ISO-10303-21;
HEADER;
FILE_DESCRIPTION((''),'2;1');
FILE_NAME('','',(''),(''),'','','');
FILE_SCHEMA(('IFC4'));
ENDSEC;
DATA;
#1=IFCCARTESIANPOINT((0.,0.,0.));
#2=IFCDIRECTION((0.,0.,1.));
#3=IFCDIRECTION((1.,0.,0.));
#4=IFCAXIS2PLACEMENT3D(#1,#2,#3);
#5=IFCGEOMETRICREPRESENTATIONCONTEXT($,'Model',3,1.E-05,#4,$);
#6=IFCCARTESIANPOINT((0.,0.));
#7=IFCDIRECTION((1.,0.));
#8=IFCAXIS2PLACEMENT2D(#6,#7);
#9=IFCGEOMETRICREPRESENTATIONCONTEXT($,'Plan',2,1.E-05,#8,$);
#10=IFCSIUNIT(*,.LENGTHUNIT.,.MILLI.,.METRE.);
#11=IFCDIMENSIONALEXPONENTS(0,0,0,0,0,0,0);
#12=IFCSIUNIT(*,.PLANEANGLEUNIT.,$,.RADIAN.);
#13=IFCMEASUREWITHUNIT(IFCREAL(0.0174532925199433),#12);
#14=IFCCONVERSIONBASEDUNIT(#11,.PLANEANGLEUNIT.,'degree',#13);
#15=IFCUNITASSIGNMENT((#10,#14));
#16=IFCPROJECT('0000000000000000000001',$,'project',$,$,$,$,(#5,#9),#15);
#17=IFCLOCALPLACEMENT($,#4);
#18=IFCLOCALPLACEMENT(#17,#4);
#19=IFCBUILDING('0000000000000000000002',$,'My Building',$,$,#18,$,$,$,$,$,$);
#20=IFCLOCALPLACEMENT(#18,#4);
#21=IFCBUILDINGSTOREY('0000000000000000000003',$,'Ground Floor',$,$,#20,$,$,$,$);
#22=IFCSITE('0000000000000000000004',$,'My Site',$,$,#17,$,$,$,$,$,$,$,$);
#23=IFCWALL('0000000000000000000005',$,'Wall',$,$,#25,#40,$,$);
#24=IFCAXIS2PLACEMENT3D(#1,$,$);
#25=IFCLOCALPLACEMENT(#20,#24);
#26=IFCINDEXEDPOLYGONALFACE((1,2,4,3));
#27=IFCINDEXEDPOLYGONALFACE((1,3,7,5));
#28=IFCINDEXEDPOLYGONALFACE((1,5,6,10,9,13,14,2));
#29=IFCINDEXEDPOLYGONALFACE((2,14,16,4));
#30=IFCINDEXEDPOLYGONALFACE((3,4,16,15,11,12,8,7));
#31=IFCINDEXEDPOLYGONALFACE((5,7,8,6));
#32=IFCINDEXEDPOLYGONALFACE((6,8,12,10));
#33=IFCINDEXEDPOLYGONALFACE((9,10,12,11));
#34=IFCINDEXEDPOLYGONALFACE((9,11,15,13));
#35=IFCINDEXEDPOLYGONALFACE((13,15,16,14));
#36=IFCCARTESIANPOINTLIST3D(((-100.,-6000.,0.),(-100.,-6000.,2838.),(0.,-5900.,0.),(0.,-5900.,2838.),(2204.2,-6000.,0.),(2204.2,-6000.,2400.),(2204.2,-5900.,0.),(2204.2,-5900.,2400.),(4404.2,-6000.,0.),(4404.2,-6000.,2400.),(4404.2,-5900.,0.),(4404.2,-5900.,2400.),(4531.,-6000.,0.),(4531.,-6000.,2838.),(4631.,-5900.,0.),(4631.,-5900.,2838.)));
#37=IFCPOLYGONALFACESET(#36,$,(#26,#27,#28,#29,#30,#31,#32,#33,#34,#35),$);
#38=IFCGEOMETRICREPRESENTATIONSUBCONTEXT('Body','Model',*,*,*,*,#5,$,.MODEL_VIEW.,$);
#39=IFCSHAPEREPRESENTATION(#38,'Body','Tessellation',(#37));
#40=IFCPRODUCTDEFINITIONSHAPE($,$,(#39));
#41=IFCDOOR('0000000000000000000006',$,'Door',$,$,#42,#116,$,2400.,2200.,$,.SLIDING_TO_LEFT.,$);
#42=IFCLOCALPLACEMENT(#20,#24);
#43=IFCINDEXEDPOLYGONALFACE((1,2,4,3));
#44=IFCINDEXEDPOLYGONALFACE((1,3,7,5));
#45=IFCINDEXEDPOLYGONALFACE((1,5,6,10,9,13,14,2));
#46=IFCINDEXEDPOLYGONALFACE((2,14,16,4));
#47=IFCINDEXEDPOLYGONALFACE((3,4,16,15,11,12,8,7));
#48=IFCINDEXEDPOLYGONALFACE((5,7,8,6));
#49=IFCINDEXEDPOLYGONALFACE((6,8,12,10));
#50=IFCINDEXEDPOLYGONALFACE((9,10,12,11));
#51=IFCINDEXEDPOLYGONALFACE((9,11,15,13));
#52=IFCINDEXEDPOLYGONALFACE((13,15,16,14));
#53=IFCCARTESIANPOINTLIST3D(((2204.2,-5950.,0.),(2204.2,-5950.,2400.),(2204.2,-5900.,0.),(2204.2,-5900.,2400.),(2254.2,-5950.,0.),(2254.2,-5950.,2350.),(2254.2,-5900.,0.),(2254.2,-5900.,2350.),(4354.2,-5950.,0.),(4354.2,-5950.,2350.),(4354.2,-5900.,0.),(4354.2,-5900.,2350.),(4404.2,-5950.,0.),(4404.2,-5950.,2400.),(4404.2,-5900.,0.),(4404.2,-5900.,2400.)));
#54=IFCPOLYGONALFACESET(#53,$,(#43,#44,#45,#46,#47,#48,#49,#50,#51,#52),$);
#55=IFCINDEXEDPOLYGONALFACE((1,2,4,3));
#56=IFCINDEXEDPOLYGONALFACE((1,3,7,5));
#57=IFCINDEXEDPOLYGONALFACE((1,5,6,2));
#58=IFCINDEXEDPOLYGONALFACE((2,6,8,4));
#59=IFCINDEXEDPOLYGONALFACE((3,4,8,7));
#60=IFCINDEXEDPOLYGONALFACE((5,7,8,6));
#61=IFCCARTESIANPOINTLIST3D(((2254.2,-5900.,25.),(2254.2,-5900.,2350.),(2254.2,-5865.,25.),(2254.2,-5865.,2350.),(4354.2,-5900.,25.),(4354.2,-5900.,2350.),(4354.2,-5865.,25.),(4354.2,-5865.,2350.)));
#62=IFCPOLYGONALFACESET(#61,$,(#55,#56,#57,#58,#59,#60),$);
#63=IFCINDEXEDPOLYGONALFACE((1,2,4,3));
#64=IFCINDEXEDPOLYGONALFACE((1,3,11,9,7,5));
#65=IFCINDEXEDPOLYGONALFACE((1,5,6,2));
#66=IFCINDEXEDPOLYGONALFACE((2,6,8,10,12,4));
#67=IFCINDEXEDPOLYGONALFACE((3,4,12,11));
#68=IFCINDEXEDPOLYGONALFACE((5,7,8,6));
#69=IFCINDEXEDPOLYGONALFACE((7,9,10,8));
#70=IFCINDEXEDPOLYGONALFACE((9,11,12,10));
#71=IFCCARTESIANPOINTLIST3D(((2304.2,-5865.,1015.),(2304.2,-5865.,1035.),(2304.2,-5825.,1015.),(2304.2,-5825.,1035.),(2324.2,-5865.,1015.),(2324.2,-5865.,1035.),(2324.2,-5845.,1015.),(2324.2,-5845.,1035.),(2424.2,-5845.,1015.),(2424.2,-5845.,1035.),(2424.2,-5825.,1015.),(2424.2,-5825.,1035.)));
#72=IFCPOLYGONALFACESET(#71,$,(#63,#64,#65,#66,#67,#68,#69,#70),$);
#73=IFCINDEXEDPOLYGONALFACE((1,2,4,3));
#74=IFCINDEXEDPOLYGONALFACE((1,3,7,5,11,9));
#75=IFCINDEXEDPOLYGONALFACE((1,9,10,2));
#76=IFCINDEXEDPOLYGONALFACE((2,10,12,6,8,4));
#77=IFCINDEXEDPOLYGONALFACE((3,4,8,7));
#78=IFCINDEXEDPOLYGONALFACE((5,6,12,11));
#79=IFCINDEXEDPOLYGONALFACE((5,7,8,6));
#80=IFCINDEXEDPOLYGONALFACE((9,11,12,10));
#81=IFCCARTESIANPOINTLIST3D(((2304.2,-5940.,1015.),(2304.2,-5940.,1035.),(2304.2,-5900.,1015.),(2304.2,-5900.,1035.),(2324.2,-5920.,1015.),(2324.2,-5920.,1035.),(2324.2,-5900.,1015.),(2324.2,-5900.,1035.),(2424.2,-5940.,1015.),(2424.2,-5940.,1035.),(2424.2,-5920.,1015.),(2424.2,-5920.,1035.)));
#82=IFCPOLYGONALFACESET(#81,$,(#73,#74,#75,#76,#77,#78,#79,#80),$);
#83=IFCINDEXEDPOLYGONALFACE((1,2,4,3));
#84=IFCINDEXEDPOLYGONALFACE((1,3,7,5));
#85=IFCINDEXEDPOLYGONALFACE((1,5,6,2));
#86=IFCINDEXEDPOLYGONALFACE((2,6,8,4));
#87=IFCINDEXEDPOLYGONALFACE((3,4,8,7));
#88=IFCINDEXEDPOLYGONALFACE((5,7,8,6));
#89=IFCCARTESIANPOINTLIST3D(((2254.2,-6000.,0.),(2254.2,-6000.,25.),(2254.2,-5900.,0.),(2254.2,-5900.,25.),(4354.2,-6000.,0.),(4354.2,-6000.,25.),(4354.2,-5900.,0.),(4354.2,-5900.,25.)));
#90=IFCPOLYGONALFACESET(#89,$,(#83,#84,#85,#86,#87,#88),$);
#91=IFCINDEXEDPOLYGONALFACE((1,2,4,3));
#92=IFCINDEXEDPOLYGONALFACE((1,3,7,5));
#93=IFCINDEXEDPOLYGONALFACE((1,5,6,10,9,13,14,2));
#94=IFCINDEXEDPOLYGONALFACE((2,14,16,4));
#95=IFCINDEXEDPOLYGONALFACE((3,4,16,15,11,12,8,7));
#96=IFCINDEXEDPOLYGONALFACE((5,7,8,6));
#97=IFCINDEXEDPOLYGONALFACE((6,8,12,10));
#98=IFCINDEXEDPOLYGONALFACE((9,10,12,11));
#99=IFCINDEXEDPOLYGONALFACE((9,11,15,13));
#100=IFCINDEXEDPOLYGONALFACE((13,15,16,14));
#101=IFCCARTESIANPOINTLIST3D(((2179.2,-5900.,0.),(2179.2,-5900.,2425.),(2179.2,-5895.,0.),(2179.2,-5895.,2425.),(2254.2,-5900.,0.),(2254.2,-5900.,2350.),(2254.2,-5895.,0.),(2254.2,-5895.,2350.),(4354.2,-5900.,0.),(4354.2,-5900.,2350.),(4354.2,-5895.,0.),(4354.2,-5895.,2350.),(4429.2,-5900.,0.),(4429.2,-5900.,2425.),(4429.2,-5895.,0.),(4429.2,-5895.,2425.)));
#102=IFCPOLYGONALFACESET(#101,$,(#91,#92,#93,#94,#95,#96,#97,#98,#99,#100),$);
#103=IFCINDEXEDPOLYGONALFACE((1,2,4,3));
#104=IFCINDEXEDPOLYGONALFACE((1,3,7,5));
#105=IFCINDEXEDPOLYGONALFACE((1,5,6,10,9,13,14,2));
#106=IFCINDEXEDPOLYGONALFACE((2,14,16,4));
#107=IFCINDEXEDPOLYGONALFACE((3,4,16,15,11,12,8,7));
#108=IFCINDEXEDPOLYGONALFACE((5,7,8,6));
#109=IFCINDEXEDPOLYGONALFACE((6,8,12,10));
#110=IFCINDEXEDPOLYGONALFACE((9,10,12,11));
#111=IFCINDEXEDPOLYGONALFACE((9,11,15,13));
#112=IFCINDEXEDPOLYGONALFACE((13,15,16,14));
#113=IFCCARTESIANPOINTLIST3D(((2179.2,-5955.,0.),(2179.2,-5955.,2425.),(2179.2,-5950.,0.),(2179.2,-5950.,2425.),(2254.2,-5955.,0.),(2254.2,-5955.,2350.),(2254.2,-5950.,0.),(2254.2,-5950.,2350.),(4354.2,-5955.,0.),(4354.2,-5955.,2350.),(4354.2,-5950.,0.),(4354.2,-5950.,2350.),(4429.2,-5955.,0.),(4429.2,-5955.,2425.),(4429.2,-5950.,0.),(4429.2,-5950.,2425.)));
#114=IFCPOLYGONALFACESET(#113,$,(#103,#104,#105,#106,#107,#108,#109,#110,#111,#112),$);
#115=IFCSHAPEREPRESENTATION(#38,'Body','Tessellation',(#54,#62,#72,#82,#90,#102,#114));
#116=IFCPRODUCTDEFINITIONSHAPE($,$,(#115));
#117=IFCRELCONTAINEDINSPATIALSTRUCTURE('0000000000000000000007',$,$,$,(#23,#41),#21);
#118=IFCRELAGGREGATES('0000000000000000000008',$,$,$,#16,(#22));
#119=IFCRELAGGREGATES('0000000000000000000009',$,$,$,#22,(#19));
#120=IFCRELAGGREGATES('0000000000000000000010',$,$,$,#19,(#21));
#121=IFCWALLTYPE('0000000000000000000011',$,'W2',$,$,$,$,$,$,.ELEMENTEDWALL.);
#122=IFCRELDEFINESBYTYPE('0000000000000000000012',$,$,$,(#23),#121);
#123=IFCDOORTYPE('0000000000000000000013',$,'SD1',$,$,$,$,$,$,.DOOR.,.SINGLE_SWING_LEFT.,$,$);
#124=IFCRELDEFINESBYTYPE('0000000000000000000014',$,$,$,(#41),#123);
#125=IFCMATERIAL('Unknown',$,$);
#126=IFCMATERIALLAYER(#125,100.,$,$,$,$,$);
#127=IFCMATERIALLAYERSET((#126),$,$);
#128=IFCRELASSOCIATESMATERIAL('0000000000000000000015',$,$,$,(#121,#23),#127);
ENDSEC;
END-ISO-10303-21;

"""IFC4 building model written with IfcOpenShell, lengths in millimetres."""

from ifc_helpers import new_model, entity, si_unit, converted_unit, frame, origin_with_axes, origin_2d_with_axis, place, context, subcontext, project, spatial, line, indexed_curve, outline, extrude, clip, halfspace, shape, source, transform, mapped, material, layer, layer_set, layer_usage, type_object, type_shapes, element, fill, save


model = new_model("IFC4")

# Units and contexts
model_context = context("Model", 3, precision=1e-05, world=origin_with_axes())
plan_context = context("Plan", 2, precision=1e-05, world=origin_2d_with_axis())
body_context_1 = subcontext(model_context, "Body", "Model", "MODEL_VIEW")
body_context_2 = subcontext(plan_context, "Body", "Plan", "PLAN_VIEW")
ifc_project = project(units=[si_unit("LENGTHUNIT", "METRE", prefix="MILLI"), converted_unit("PLANEANGLEUNIT", "degree", entity("IfcReal", 0.0174532925199433), si_unit("PLANEANGLEUNIT", "RADIAN"), dimensions=[0, 0, 0, 0, 0, 0, 0])], contexts=[model_context, plan_context])

# Site, building, storey
site_placement = place(None, origin_with_axes())
site = spatial("IfcSite", under=ifc_project, at=site_placement, Name="My Site")
building_placement = place(site_placement, origin_with_axes())
building = spatial("IfcBuilding", under=site, at=building_placement, Name="My Building")
storey_placement = place(building_placement, origin_with_axes())
storey = spatial("IfcBuildingStorey", under=building, at=storey_placement, Name="Ground Floor")

# Shared definitions
ifc_material = material(Name="Unknown")

# Shared definitions
ifc_layer_1 = layer(ifc_material, 100.0)
ifc_layer_set_1 = layer_set([ifc_layer_1])
wall_type = type_object("IfcWallType", Name="W2", PredefinedType="ELEMENTEDWALL", material=ifc_layer_set_1)

# Wall, opening, door
ifc_layer_usage_1 = layer_usage(ifc_layer_set_1, "AXIS2", "POSITIVE", 0.0)
wall_1_placement = place(storey_placement, frame((4631.0, -5900.0, 0.0), z_axis=(0.0, 0.0, 1.0), x_axis=(-1.0, 0.0, 0.0)))
wall_1 = element("IfcWall", 1, at=wall_1_placement, inside=storey, type_object=wall_type, material=ifc_layer_usage_1, Name="Wall", context=body_context_1, shape_type="Clipping", body=[
    clip(clip(extrude(outline(indexed_curve([(0.0, 0.0), (0.0, 100.0), (4731.0, 100.0), (4731.0, 0.0), (0.0, 0.0)], self_intersect=False)), origin_with_axes(), (0.0, 0.0, 1.0), 2838.0), halfspace(frame((4631.0, 0.0, 0.0), z_axis=(0.707107, -0.707107, 0.0), x_axis=(-0.707107, -0.707107, 0.0)), False)), halfspace(frame((0.0, 0.0, 0.0), z_axis=(-0.707107, 0.707106, 0.0), x_axis=(0.707106, 0.707107, 0.0)), False)),
])
shared_shape_1 = source(origin_with_axes(), body_context_1, "Body", "SolidModel", [
    extrude(outline(indexed_curve([(0.0, 0.0), (2200.0, 0.0), (2200.0, 2400.0), (0.0, 2400.0)], segments=[line(1, 2, 3, 4, 1)])), frame((0.0, -600.0, 0.0), z_axis=(0.0, -1.0, 0.0), x_axis=(1.0, 0.0, 0.0)), (0.0, 0.0, -1.0), 1200.0),
])
opening_1_placement = place(wall_1_placement, frame((226.8, 0.0, 0.0), z_axis=(0.0, 0.0, 1.0), x_axis=(1.0, 0.0, 0.0)))
opening_1 = element("IfcOpeningElement", 2, at=opening_1_placement, cuts=wall_1, PredefinedType="OPENING", context=body_context_1, shape_type="MappedRepresentation", body=[
    mapped(shared_shape_1, transform((0.0, 0.0, 0.0), x_axis=(1.0, 0.0, 0.0), y_axis=(0.0, 1.0, 0.0), z_axis=(0.0, 0.0, 1.0), scale=1.0)),
])
door_type_1 = type_object("IfcDoorType", Name="SD1", OperationType="SINGLE_SWING_LEFT", PredefinedType="DOOR")
shared_shape_2 = source(origin_with_axes(), body_context_1, "Body", "SolidModel", [
    extrude(outline(indexed_curve([(0.0, 0.0), (0.0, 2400.0), (2200.0, 2400.0), (2200.0, 0.0), (2150.0, 0.0), (2150.0, 2350.0), (50.0, 2350.0), (50.0, 0.0)], segments=[line(1, 2, 3, 4, 5, 6, 7, 8, 1)])), frame((0.0, 0.0, 0.0), z_axis=(0.0, -1.0, 0.0), x_axis=(1.0, 0.0, 0.0)), (0.0, 0.0, -1.0), 50.0),
    extrude(outline(indexed_curve([(0.0, 0.0), (2100.0, 0.0), (2100.0, 35.0), (0.0, 35.0)], segments=[line(1, 2, 3, 4, 1)])), frame((50.0, -35.0, 25.0), z_axis=(0.0, 0.0, 1.0), x_axis=(1.0, 0.0, 0.0)), (0.0, 0.0, 1.0), 2325.0),
    extrude(outline(indexed_curve([(0.0, 0.0), (0.0, -40.0), (-120.0, -40.0), (-120.0, -20.0), (-20.0, -20.0), (-20.0, 0.0)], segments=[line(1, 2, 3, 4, 5, 6, 1)])), frame((2100.0, -35.0, 1015.0), z_axis=(0.0, 0.0, 1.0), x_axis=(1.0, 0.0, 0.0)), (0.0, 0.0, 1.0), 20.0),
    extrude(outline(indexed_curve([(0.0, 0.0), (0.0, 40.0), (-120.0, 40.0), (-120.0, 20.0), (-20.0, 20.0), (-20.0, 0.0)], segments=[line(1, 2, 3, 4, 5, 6, 1)])), frame((2100.0, 0.0, 1015.0), z_axis=(0.0, 0.0, 1.0), x_axis=(1.0, 0.0, 0.0)), (0.0, 0.0, 1.0), 20.0),
    extrude(outline(indexed_curve([(0.0, 0.0), (2100.0, 0.0), (2100.0, 100.0), (0.0, 100.0)], segments=[line(1, 2, 3, 4, 1)])), frame((50.0, 0.0, 0.0), z_axis=(0.0, 0.0, 1.0), x_axis=(1.0, 0.0, 0.0)), (0.0, 0.0, 1.0), 25.0),
    extrude(outline(indexed_curve([(0.0, 0.0), (0.0, 2425.0), (2250.0, 2425.0), (2250.0, 0.0), (2175.0, 0.0), (2175.0, 2350.0), (75.0, 2350.0), (75.0, 0.0)], segments=[line(1, 2, 3, 4, 5, 6, 7, 8, 1)])), frame((-25.0, -5.0, 0.0), z_axis=(0.0, -1.0, 0.0), x_axis=(1.0, 0.0, 0.0)), (0.0, 0.0, -1.0), 5.0),
    extrude(outline(indexed_curve([(0.0, 0.0), (0.0, 2425.0), (2250.0, 2425.0), (2250.0, 0.0), (2175.0, 0.0), (2175.0, 2350.0), (75.0, 2350.0), (75.0, 0.0)], segments=[line(1, 2, 3, 4, 5, 6, 7, 8, 1)])), frame((-25.0, 50.0, 0.0), z_axis=(0.0, -1.0, 0.0), x_axis=(1.0, 0.0, 0.0)), (0.0, 0.0, -1.0), 5.0),
])
shared_shape_3 = source(origin_with_axes(), body_context_2, "Body", "Curve2D", [
    entity("IfcIndexedPolyCurve", entity("IfcCartesianPointList2D", [[0.0, 0.0], [50.0, 0.0], [50.0, 50.0], [0.0, 50.0]]), [entity("IfcLineIndex", [1, 2, 3, 4, 1])]),
    entity("IfcIndexedPolyCurve", entity("IfcCartesianPointList2D", [[2200.0, 0.0], [2150.0, 0.0], [2150.0, 50.0], [2200.0, 50.0]]), [entity("IfcLineIndex", [1, 2, 3, 4, 1])]),
    entity("IfcIndexedPolyCurve", entity("IfcCartesianPointList2D", [[-1000.0, -35.0], [1100.0, -35.0], [1100.0, 0.0], [-1000.0, 0.0]]), [entity("IfcLineIndex", [1, 2, 3, 4, 1])]),
])
type_shapes(door_type_1, [shared_shape_2, shared_shape_3])
door_1_placement = place(opening_1_placement, frame((0.0, 0.0, 0.0), z_axis=(0.0, 0.0, 1.0), x_axis=(1.0, 0.0, 0.0)))
door_1 = element("IfcDoor", 3, at=door_1_placement, inside=storey, type_object=door_type_1, Name="Door", OperationType="SLIDING_TO_LEFT", OverallHeight=2400.0, OverallWidth=2200.0, shapes=[
    shape(body_context_1, "Body", "MappedRepresentation", [mapped(shared_shape_2, transform((0.0, 0.0, 0.0), x_axis=(1.0, 0.0, 0.0), y_axis=(0.0, 1.0, 0.0), z_axis=(0.0, 0.0, 1.0), scale=1.0))]),
    shape(body_context_2, "Body", "MappedRepresentation", [mapped(shared_shape_3, transform((0.0, 0.0, 0.0), x_axis=(1.0, 0.0, 0.0), y_axis=(0.0, 1.0, 0.0), z_axis=(0.0, 0.0, 1.0), scale=1.0))]),
])
fill(opening_1, door_1)

save(model, "model.ifc")
